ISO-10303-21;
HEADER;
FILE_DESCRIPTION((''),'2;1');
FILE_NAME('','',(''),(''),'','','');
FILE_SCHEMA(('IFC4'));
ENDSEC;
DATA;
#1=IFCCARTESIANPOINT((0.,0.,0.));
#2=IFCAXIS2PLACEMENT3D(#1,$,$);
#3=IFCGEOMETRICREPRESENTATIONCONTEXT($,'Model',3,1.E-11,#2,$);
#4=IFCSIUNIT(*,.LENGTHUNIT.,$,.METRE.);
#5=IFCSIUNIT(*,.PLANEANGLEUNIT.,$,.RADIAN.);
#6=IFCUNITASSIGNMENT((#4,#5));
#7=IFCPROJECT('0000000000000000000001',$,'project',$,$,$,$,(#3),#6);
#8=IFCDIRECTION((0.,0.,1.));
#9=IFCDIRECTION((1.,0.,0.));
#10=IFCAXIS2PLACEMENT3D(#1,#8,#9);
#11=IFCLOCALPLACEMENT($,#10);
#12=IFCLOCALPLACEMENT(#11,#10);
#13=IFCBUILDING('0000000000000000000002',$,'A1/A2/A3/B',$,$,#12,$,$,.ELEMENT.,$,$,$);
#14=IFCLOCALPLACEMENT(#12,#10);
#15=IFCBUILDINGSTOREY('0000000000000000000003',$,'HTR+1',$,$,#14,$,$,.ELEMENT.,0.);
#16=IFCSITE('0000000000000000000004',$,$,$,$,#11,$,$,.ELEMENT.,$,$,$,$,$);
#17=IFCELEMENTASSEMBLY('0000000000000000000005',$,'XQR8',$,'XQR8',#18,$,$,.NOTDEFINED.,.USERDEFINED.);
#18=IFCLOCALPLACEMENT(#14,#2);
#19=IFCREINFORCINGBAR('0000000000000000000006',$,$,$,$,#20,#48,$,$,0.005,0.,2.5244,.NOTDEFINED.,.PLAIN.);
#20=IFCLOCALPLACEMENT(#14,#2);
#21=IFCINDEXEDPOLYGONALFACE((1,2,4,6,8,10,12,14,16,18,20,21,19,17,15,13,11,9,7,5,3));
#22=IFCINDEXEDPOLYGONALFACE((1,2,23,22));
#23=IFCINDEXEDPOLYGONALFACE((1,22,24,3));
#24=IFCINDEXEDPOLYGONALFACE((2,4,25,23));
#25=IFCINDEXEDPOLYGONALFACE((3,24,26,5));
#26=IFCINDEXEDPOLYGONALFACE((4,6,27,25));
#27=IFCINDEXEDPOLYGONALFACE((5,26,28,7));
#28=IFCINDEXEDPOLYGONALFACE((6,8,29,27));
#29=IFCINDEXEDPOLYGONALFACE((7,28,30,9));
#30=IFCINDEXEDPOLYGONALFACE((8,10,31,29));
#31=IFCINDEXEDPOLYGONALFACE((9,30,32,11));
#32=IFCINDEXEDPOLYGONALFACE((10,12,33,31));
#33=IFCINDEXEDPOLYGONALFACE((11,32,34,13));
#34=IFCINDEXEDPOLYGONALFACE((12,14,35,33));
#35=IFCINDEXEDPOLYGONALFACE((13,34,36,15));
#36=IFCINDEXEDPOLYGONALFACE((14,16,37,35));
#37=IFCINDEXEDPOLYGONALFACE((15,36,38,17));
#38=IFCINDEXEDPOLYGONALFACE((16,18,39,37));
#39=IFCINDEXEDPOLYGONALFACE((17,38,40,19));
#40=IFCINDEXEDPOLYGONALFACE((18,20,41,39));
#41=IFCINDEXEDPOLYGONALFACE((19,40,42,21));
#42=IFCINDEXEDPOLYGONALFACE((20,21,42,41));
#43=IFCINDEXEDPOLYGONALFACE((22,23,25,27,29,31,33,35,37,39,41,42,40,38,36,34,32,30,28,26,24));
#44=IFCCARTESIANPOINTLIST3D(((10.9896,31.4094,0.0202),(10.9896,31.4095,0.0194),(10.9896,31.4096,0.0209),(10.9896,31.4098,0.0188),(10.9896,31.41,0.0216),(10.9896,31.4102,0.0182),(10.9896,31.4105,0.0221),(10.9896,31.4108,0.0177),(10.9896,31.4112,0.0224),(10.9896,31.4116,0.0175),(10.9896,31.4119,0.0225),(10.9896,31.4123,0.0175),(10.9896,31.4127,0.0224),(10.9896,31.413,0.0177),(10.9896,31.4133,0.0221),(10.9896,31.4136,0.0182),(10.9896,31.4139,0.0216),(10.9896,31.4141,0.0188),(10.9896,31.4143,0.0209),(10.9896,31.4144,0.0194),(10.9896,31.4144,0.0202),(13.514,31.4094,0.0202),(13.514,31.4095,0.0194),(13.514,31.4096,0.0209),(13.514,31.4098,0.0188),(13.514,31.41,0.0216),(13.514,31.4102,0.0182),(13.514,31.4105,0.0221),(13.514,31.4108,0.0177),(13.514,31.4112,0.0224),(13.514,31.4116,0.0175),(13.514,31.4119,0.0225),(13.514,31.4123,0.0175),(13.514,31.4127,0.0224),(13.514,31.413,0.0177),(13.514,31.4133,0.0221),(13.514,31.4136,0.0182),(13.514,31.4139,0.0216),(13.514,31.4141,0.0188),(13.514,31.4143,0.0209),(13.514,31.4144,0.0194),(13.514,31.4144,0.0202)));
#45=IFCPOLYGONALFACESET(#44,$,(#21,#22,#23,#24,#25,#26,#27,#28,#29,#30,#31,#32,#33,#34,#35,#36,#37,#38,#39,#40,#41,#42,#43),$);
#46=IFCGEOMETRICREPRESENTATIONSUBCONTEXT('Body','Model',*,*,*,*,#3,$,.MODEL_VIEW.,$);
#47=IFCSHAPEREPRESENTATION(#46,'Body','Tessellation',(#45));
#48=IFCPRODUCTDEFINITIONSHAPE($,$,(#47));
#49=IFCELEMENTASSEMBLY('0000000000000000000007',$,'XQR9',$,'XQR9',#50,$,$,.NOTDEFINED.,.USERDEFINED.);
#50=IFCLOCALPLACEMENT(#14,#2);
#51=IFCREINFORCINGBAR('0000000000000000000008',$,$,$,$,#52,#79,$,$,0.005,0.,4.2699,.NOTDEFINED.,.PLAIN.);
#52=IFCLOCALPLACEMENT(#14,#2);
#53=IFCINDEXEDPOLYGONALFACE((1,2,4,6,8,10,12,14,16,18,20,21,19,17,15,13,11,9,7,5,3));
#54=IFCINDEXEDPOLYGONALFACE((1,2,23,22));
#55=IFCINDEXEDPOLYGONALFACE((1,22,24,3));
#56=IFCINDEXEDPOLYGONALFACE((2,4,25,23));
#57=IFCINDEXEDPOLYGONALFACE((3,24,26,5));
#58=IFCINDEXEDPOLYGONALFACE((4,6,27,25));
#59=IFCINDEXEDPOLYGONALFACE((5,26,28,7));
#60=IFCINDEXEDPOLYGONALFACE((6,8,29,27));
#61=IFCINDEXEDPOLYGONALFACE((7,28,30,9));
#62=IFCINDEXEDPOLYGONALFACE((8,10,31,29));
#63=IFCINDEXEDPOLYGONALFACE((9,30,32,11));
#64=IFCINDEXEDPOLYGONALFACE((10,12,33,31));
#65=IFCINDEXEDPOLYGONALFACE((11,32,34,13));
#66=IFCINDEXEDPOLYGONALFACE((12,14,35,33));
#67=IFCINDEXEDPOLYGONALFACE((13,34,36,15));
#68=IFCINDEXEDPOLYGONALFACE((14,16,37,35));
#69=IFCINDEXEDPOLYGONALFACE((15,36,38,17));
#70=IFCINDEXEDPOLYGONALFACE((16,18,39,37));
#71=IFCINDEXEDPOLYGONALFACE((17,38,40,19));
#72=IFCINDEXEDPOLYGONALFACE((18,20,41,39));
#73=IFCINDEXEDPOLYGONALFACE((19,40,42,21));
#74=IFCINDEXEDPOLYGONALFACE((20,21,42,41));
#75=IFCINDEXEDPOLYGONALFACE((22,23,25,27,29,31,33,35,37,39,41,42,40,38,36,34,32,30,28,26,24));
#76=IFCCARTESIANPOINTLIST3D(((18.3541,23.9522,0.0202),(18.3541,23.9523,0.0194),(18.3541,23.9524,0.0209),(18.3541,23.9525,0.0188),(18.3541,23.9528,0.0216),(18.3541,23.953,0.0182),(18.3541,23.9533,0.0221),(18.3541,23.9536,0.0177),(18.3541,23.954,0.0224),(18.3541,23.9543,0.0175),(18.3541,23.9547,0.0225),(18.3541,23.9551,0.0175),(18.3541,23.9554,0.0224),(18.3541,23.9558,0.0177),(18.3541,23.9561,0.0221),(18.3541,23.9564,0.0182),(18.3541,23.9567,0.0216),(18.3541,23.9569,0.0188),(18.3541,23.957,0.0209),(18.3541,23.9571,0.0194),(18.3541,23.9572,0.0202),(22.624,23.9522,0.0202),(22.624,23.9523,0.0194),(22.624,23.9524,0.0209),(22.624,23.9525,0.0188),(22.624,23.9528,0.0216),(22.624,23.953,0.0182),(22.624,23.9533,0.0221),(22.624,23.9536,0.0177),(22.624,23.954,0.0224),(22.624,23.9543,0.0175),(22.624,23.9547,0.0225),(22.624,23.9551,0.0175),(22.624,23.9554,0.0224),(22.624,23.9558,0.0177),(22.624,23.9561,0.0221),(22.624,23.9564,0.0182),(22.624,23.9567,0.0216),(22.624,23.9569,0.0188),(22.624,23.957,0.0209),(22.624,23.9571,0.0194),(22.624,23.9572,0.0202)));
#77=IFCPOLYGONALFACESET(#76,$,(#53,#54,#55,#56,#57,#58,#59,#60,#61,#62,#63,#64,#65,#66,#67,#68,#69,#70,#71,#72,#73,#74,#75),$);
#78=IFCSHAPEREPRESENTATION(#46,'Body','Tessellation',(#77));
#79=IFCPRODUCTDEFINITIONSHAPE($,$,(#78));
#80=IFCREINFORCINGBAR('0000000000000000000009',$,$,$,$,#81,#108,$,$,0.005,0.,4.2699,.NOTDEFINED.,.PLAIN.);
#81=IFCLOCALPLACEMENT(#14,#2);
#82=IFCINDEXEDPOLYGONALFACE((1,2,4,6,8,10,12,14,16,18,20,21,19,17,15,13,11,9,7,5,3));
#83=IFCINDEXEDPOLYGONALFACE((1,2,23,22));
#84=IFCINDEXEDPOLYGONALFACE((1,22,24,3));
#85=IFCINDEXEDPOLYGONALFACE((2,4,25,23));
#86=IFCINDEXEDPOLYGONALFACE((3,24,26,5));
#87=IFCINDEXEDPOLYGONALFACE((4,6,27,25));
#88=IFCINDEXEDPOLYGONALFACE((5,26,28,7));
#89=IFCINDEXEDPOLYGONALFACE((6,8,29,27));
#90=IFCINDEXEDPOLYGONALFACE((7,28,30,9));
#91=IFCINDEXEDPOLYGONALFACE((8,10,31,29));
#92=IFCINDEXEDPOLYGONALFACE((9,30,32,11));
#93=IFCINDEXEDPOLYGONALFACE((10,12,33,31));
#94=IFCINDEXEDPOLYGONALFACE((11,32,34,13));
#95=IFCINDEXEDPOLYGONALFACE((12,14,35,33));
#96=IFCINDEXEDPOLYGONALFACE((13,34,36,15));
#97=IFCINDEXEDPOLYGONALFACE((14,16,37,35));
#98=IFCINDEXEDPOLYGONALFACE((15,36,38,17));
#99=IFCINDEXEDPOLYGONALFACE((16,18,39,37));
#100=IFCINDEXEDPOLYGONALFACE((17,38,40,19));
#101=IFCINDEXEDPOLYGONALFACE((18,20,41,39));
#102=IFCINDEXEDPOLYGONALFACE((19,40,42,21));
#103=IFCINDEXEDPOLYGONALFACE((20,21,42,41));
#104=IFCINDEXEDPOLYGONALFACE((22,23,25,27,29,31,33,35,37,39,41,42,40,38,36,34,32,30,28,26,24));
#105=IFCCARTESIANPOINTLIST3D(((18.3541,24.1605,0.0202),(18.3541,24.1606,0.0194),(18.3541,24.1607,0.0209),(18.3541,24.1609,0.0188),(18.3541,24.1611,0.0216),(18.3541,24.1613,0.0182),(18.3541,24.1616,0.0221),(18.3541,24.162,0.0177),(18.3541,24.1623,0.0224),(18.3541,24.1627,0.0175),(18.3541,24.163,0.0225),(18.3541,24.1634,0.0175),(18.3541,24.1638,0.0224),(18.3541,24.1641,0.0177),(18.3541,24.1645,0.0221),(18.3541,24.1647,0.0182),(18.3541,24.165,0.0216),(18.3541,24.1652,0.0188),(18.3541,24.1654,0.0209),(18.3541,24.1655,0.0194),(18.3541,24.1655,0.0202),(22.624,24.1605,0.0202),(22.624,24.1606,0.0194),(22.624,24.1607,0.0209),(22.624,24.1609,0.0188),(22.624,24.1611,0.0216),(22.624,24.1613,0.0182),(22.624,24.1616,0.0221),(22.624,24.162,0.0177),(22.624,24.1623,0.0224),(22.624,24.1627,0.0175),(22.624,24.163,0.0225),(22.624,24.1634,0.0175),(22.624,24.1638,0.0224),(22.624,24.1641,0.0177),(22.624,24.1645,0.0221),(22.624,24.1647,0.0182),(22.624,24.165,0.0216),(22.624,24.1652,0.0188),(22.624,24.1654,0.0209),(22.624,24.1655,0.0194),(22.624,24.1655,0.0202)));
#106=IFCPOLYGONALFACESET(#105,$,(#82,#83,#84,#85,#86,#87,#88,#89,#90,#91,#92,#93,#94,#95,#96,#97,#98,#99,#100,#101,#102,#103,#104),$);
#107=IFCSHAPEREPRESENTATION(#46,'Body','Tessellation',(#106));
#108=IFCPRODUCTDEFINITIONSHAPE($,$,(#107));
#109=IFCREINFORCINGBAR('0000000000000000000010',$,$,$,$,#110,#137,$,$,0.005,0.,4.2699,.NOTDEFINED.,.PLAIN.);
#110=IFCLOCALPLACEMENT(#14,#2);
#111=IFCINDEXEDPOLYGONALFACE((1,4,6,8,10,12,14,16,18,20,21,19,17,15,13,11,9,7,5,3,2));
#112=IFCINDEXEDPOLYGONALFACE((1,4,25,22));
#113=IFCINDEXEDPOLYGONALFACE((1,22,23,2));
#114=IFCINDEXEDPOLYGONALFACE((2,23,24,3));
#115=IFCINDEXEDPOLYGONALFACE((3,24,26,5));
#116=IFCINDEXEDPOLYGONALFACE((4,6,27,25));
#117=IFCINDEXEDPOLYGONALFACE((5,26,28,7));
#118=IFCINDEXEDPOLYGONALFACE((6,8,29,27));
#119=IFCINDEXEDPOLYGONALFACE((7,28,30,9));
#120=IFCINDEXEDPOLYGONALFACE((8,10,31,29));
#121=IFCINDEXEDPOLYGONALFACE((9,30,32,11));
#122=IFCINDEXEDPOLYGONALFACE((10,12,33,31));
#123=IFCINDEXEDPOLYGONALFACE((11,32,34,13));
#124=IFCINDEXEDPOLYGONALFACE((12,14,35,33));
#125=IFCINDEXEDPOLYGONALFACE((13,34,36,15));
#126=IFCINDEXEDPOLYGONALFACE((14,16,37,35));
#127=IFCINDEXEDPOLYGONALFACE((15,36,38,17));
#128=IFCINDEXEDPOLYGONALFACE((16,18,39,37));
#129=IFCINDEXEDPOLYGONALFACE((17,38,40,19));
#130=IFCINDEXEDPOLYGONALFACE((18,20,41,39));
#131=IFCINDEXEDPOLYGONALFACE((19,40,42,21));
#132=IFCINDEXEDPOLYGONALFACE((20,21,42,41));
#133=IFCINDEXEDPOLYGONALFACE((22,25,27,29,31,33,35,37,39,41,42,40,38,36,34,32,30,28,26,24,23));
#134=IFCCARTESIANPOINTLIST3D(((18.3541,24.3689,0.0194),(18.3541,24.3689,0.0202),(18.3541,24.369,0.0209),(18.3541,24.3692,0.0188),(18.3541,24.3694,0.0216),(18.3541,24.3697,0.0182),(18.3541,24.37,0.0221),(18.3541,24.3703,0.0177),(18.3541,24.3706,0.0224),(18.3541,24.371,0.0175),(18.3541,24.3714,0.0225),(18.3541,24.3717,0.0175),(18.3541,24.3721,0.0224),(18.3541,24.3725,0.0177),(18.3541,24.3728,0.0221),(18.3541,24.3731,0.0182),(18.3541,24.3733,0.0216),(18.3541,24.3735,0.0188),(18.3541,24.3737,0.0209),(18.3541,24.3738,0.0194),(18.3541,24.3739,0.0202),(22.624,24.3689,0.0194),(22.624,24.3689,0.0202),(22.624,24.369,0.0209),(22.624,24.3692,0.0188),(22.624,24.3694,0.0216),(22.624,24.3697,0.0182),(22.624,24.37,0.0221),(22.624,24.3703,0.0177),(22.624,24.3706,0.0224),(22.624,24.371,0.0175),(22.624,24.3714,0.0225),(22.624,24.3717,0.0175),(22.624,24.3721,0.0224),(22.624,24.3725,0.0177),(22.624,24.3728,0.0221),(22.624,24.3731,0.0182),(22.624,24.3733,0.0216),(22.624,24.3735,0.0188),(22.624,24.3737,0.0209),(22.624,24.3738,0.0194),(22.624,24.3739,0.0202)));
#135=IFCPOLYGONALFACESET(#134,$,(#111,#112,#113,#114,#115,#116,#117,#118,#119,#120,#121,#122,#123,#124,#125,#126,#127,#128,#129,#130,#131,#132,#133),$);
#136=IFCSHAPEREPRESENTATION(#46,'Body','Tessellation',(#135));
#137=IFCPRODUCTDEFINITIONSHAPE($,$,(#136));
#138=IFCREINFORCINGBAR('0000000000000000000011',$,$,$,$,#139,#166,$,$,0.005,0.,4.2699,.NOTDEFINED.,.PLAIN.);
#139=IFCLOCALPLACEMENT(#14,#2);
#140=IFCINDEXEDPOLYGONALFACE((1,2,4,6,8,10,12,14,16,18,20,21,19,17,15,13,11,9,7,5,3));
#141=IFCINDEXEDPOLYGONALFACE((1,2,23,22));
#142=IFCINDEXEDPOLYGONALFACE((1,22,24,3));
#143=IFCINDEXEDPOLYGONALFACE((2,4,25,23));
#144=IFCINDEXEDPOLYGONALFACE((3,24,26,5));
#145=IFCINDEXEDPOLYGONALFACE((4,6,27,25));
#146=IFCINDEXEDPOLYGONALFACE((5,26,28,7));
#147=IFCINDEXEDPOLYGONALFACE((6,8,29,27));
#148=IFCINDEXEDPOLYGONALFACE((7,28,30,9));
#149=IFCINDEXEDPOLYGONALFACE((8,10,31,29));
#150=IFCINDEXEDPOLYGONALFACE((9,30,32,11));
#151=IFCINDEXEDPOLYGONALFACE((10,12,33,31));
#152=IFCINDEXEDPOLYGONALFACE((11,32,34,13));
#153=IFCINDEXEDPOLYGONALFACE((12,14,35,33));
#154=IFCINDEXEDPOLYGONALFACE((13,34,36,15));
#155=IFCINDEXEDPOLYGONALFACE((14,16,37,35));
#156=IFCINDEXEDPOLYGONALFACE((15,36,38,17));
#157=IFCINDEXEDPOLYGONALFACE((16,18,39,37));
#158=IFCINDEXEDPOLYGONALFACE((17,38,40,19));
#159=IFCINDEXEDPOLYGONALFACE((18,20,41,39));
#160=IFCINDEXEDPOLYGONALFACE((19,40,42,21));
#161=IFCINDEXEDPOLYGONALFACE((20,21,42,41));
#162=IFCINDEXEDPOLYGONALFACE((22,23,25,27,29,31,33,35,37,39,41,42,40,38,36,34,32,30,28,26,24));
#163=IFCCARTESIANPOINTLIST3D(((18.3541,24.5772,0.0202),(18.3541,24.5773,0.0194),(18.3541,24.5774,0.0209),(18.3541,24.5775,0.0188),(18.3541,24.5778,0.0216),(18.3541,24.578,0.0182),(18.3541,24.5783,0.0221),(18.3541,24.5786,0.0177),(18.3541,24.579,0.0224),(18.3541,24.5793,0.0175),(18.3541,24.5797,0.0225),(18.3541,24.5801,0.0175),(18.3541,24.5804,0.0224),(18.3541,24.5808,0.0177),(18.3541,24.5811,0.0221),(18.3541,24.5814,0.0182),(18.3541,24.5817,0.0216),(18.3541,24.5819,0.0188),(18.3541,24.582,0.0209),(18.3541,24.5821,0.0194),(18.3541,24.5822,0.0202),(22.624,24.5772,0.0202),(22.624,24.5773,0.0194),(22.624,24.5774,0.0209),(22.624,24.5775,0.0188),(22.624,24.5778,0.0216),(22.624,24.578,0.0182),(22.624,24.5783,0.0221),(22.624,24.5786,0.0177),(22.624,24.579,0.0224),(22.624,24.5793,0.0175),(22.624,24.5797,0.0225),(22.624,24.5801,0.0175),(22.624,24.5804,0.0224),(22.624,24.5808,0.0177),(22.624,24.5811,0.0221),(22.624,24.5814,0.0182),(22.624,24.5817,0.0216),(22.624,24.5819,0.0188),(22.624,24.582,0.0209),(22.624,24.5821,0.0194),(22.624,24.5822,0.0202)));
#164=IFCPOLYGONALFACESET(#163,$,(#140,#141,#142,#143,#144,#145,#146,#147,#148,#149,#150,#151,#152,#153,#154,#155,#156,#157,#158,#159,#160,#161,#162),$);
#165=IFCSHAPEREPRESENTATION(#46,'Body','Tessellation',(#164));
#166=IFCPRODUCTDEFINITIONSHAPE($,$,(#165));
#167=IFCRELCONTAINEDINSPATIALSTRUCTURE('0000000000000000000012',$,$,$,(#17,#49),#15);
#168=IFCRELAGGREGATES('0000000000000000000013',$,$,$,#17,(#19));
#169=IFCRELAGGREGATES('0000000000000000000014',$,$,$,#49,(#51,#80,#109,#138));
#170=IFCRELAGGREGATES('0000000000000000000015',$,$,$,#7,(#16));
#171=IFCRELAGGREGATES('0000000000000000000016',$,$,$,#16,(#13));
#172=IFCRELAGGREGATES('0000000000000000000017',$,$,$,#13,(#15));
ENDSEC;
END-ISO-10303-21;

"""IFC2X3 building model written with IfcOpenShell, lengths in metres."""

from ifc_helpers import new_model, entity, si_unit, origin, origin_with_axes, place, context, subcontext, project, spatial, shape, element, aggregate, save


model = new_model("IFC2X3")

# Units and contexts
model_context = context("Model", 3, precision=1e-11, world=origin())
body_context = subcontext(model_context, "Body", "Model", "MODEL_VIEW")
ifc_project = project(units=[si_unit("LENGTHUNIT", "METRE"), si_unit("PLANEANGLEUNIT", "RADIAN")], contexts=[model_context])

# Site, building, storey
site_placement = place(None, origin_with_axes())
site = spatial("IfcSite", under=ifc_project, at=site_placement, CompositionType="ELEMENT")
building_placement = place(site_placement, origin_with_axes())
building = spatial("IfcBuilding", under=site, at=building_placement, Name="A1/A2/A3/B", CompositionType="ELEMENT")
storey_placement = place(building_placement, origin_with_axes())
storey = spatial("IfcBuildingStorey", under=building, at=storey_placement, Name="HTR+1", CompositionType="ELEMENT", Elevation=0.0)

# Element assemblies, reinforcing bars
assembly_1_placement = place(storey_placement, origin_with_axes())
assembly_1 = element("IfcElementAssembly", 1, at=assembly_1_placement, inside=storey, Name="XQR8", ObjectType="XQR8", AssemblyPlace="NOTDEFINED", PredefinedType="USERDEFINED")
reinforcing_bar_1_placement = place(assembly_1_placement, origin_with_axes())
reinforcing_bar_1 = element("IfcReinforcingBar", 2, at=reinforcing_bar_1_placement, BarLength=2.5244, BarRole="NOTDEFINED", BarSurface="PLAIN", CrossSectionArea=0.0, NominalDiameter=0.005, shapes=[
    shape(body_context, "Body", "AdvancedSweptSolid", [entity("IfcSweptDiskSolid", entity("IfcPolyline", [entity("IfcCartesianPoint", [10.9896, 31.4119, 0.02]), entity("IfcCartesianPoint", [13.514, 31.4119, 0.02])]), 0.0025, None, 0.0, 2.5244)]),
    shape(body_context, "Body", "AdvancedSweptSolid", [entity("IfcSweptDiskSolid", entity("IfcPolyline", [entity("IfcCartesianPoint", [10.9896, 31.4119, 0.02]), entity("IfcCartesianPoint", [13.514, 31.4119, 0.02])]), 0.0025, None, 0.0, 2.5244)]),
])
aggregate(assembly_1, [reinforcing_bar_1])
assembly_2_placement = place(storey_placement, origin_with_axes())
assembly_2 = element("IfcElementAssembly", 3, at=assembly_2_placement, inside=storey, Name="XQR9", ObjectType="XQR9", AssemblyPlace="NOTDEFINED", PredefinedType="USERDEFINED")
reinforcing_bar_2_placement = place(assembly_2_placement, origin_with_axes())
reinforcing_bar_2 = element("IfcReinforcingBar", 4, at=reinforcing_bar_2_placement, BarLength=4.2699, BarRole="NOTDEFINED", BarSurface="PLAIN", CrossSectionArea=0.0, NominalDiameter=0.005, shapes=[
    shape(body_context, "Body", "AdvancedSweptSolid", [entity("IfcSweptDiskSolid", entity("IfcPolyline", [entity("IfcCartesianPoint", [18.3541, 23.9547, 0.02]), entity("IfcCartesianPoint", [22.624, 23.9547, 0.02])]), 0.0025, None, 0.0, 4.2699)]),
    shape(body_context, "Body", "AdvancedSweptSolid", [entity("IfcSweptDiskSolid", entity("IfcPolyline", [entity("IfcCartesianPoint", [18.3541, 23.9547, 0.02]), entity("IfcCartesianPoint", [22.624, 23.9547, 0.02])]), 0.0025, None, 0.0, 4.2699)]),
])
reinforcing_bar_3_placement = place(assembly_2_placement, origin_with_axes())
reinforcing_bar_3 = element("IfcReinforcingBar", 5, at=reinforcing_bar_3_placement, BarLength=4.2699, BarRole="NOTDEFINED", BarSurface="PLAIN", CrossSectionArea=0.0, NominalDiameter=0.005, shapes=[
    shape(body_context, "Body", "AdvancedSweptSolid", [entity("IfcSweptDiskSolid", entity("IfcPolyline", [entity("IfcCartesianPoint", [18.3541, 24.163, 0.02]), entity("IfcCartesianPoint", [22.624, 24.163, 0.02])]), 0.0025, None, 0.0, 4.2699)]),
    shape(body_context, "Body", "AdvancedSweptSolid", [entity("IfcSweptDiskSolid", entity("IfcPolyline", [entity("IfcCartesianPoint", [18.3541, 24.163, 0.02]), entity("IfcCartesianPoint", [22.624, 24.163, 0.02])]), 0.0025, None, 0.0, 4.2699)]),
])
reinforcing_bar_4_placement = place(assembly_2_placement, origin_with_axes())
reinforcing_bar_4 = element("IfcReinforcingBar", 6, at=reinforcing_bar_4_placement, BarLength=4.2699, BarRole="NOTDEFINED", BarSurface="PLAIN", CrossSectionArea=0.0, NominalDiameter=0.005, shapes=[
    shape(body_context, "Body", "AdvancedSweptSolid", [entity("IfcSweptDiskSolid", entity("IfcPolyline", [entity("IfcCartesianPoint", [18.3541, 24.3714, 0.02]), entity("IfcCartesianPoint", [22.624, 24.3714, 0.02])]), 0.0025, None, 0.0, 4.2699)]),
    shape(body_context, "Body", "AdvancedSweptSolid", [entity("IfcSweptDiskSolid", entity("IfcPolyline", [entity("IfcCartesianPoint", [18.3541, 24.3714, 0.02]), entity("IfcCartesianPoint", [22.624, 24.3714, 0.02])]), 0.0025, None, 0.0, 4.2699)]),
])
reinforcing_bar_5_placement = place(assembly_2_placement, origin_with_axes())
reinforcing_bar_5 = element("IfcReinforcingBar", 7, at=reinforcing_bar_5_placement, BarLength=4.2699, BarRole="NOTDEFINED", BarSurface="PLAIN", CrossSectionArea=0.0, NominalDiameter=0.005, shapes=[
    shape(body_context, "Body", "AdvancedSweptSolid", [entity("IfcSweptDiskSolid", entity("IfcPolyline", [entity("IfcCartesianPoint", [18.3541, 24.5797, 0.02]), entity("IfcCartesianPoint", [22.624, 24.5797, 0.02])]), 0.0025, None, 0.0, 4.2699)]),
    shape(body_context, "Body", "AdvancedSweptSolid", [entity("IfcSweptDiskSolid", entity("IfcPolyline", [entity("IfcCartesianPoint", [18.3541, 24.5797, 0.02]), entity("IfcCartesianPoint", [22.624, 24.5797, 0.02])]), 0.0025, None, 0.0, 4.2699)]),
])
aggregate(assembly_2, [reinforcing_bar_2, reinforcing_bar_3, reinforcing_bar_4, reinforcing_bar_5])

save(model, "model.ifc")
